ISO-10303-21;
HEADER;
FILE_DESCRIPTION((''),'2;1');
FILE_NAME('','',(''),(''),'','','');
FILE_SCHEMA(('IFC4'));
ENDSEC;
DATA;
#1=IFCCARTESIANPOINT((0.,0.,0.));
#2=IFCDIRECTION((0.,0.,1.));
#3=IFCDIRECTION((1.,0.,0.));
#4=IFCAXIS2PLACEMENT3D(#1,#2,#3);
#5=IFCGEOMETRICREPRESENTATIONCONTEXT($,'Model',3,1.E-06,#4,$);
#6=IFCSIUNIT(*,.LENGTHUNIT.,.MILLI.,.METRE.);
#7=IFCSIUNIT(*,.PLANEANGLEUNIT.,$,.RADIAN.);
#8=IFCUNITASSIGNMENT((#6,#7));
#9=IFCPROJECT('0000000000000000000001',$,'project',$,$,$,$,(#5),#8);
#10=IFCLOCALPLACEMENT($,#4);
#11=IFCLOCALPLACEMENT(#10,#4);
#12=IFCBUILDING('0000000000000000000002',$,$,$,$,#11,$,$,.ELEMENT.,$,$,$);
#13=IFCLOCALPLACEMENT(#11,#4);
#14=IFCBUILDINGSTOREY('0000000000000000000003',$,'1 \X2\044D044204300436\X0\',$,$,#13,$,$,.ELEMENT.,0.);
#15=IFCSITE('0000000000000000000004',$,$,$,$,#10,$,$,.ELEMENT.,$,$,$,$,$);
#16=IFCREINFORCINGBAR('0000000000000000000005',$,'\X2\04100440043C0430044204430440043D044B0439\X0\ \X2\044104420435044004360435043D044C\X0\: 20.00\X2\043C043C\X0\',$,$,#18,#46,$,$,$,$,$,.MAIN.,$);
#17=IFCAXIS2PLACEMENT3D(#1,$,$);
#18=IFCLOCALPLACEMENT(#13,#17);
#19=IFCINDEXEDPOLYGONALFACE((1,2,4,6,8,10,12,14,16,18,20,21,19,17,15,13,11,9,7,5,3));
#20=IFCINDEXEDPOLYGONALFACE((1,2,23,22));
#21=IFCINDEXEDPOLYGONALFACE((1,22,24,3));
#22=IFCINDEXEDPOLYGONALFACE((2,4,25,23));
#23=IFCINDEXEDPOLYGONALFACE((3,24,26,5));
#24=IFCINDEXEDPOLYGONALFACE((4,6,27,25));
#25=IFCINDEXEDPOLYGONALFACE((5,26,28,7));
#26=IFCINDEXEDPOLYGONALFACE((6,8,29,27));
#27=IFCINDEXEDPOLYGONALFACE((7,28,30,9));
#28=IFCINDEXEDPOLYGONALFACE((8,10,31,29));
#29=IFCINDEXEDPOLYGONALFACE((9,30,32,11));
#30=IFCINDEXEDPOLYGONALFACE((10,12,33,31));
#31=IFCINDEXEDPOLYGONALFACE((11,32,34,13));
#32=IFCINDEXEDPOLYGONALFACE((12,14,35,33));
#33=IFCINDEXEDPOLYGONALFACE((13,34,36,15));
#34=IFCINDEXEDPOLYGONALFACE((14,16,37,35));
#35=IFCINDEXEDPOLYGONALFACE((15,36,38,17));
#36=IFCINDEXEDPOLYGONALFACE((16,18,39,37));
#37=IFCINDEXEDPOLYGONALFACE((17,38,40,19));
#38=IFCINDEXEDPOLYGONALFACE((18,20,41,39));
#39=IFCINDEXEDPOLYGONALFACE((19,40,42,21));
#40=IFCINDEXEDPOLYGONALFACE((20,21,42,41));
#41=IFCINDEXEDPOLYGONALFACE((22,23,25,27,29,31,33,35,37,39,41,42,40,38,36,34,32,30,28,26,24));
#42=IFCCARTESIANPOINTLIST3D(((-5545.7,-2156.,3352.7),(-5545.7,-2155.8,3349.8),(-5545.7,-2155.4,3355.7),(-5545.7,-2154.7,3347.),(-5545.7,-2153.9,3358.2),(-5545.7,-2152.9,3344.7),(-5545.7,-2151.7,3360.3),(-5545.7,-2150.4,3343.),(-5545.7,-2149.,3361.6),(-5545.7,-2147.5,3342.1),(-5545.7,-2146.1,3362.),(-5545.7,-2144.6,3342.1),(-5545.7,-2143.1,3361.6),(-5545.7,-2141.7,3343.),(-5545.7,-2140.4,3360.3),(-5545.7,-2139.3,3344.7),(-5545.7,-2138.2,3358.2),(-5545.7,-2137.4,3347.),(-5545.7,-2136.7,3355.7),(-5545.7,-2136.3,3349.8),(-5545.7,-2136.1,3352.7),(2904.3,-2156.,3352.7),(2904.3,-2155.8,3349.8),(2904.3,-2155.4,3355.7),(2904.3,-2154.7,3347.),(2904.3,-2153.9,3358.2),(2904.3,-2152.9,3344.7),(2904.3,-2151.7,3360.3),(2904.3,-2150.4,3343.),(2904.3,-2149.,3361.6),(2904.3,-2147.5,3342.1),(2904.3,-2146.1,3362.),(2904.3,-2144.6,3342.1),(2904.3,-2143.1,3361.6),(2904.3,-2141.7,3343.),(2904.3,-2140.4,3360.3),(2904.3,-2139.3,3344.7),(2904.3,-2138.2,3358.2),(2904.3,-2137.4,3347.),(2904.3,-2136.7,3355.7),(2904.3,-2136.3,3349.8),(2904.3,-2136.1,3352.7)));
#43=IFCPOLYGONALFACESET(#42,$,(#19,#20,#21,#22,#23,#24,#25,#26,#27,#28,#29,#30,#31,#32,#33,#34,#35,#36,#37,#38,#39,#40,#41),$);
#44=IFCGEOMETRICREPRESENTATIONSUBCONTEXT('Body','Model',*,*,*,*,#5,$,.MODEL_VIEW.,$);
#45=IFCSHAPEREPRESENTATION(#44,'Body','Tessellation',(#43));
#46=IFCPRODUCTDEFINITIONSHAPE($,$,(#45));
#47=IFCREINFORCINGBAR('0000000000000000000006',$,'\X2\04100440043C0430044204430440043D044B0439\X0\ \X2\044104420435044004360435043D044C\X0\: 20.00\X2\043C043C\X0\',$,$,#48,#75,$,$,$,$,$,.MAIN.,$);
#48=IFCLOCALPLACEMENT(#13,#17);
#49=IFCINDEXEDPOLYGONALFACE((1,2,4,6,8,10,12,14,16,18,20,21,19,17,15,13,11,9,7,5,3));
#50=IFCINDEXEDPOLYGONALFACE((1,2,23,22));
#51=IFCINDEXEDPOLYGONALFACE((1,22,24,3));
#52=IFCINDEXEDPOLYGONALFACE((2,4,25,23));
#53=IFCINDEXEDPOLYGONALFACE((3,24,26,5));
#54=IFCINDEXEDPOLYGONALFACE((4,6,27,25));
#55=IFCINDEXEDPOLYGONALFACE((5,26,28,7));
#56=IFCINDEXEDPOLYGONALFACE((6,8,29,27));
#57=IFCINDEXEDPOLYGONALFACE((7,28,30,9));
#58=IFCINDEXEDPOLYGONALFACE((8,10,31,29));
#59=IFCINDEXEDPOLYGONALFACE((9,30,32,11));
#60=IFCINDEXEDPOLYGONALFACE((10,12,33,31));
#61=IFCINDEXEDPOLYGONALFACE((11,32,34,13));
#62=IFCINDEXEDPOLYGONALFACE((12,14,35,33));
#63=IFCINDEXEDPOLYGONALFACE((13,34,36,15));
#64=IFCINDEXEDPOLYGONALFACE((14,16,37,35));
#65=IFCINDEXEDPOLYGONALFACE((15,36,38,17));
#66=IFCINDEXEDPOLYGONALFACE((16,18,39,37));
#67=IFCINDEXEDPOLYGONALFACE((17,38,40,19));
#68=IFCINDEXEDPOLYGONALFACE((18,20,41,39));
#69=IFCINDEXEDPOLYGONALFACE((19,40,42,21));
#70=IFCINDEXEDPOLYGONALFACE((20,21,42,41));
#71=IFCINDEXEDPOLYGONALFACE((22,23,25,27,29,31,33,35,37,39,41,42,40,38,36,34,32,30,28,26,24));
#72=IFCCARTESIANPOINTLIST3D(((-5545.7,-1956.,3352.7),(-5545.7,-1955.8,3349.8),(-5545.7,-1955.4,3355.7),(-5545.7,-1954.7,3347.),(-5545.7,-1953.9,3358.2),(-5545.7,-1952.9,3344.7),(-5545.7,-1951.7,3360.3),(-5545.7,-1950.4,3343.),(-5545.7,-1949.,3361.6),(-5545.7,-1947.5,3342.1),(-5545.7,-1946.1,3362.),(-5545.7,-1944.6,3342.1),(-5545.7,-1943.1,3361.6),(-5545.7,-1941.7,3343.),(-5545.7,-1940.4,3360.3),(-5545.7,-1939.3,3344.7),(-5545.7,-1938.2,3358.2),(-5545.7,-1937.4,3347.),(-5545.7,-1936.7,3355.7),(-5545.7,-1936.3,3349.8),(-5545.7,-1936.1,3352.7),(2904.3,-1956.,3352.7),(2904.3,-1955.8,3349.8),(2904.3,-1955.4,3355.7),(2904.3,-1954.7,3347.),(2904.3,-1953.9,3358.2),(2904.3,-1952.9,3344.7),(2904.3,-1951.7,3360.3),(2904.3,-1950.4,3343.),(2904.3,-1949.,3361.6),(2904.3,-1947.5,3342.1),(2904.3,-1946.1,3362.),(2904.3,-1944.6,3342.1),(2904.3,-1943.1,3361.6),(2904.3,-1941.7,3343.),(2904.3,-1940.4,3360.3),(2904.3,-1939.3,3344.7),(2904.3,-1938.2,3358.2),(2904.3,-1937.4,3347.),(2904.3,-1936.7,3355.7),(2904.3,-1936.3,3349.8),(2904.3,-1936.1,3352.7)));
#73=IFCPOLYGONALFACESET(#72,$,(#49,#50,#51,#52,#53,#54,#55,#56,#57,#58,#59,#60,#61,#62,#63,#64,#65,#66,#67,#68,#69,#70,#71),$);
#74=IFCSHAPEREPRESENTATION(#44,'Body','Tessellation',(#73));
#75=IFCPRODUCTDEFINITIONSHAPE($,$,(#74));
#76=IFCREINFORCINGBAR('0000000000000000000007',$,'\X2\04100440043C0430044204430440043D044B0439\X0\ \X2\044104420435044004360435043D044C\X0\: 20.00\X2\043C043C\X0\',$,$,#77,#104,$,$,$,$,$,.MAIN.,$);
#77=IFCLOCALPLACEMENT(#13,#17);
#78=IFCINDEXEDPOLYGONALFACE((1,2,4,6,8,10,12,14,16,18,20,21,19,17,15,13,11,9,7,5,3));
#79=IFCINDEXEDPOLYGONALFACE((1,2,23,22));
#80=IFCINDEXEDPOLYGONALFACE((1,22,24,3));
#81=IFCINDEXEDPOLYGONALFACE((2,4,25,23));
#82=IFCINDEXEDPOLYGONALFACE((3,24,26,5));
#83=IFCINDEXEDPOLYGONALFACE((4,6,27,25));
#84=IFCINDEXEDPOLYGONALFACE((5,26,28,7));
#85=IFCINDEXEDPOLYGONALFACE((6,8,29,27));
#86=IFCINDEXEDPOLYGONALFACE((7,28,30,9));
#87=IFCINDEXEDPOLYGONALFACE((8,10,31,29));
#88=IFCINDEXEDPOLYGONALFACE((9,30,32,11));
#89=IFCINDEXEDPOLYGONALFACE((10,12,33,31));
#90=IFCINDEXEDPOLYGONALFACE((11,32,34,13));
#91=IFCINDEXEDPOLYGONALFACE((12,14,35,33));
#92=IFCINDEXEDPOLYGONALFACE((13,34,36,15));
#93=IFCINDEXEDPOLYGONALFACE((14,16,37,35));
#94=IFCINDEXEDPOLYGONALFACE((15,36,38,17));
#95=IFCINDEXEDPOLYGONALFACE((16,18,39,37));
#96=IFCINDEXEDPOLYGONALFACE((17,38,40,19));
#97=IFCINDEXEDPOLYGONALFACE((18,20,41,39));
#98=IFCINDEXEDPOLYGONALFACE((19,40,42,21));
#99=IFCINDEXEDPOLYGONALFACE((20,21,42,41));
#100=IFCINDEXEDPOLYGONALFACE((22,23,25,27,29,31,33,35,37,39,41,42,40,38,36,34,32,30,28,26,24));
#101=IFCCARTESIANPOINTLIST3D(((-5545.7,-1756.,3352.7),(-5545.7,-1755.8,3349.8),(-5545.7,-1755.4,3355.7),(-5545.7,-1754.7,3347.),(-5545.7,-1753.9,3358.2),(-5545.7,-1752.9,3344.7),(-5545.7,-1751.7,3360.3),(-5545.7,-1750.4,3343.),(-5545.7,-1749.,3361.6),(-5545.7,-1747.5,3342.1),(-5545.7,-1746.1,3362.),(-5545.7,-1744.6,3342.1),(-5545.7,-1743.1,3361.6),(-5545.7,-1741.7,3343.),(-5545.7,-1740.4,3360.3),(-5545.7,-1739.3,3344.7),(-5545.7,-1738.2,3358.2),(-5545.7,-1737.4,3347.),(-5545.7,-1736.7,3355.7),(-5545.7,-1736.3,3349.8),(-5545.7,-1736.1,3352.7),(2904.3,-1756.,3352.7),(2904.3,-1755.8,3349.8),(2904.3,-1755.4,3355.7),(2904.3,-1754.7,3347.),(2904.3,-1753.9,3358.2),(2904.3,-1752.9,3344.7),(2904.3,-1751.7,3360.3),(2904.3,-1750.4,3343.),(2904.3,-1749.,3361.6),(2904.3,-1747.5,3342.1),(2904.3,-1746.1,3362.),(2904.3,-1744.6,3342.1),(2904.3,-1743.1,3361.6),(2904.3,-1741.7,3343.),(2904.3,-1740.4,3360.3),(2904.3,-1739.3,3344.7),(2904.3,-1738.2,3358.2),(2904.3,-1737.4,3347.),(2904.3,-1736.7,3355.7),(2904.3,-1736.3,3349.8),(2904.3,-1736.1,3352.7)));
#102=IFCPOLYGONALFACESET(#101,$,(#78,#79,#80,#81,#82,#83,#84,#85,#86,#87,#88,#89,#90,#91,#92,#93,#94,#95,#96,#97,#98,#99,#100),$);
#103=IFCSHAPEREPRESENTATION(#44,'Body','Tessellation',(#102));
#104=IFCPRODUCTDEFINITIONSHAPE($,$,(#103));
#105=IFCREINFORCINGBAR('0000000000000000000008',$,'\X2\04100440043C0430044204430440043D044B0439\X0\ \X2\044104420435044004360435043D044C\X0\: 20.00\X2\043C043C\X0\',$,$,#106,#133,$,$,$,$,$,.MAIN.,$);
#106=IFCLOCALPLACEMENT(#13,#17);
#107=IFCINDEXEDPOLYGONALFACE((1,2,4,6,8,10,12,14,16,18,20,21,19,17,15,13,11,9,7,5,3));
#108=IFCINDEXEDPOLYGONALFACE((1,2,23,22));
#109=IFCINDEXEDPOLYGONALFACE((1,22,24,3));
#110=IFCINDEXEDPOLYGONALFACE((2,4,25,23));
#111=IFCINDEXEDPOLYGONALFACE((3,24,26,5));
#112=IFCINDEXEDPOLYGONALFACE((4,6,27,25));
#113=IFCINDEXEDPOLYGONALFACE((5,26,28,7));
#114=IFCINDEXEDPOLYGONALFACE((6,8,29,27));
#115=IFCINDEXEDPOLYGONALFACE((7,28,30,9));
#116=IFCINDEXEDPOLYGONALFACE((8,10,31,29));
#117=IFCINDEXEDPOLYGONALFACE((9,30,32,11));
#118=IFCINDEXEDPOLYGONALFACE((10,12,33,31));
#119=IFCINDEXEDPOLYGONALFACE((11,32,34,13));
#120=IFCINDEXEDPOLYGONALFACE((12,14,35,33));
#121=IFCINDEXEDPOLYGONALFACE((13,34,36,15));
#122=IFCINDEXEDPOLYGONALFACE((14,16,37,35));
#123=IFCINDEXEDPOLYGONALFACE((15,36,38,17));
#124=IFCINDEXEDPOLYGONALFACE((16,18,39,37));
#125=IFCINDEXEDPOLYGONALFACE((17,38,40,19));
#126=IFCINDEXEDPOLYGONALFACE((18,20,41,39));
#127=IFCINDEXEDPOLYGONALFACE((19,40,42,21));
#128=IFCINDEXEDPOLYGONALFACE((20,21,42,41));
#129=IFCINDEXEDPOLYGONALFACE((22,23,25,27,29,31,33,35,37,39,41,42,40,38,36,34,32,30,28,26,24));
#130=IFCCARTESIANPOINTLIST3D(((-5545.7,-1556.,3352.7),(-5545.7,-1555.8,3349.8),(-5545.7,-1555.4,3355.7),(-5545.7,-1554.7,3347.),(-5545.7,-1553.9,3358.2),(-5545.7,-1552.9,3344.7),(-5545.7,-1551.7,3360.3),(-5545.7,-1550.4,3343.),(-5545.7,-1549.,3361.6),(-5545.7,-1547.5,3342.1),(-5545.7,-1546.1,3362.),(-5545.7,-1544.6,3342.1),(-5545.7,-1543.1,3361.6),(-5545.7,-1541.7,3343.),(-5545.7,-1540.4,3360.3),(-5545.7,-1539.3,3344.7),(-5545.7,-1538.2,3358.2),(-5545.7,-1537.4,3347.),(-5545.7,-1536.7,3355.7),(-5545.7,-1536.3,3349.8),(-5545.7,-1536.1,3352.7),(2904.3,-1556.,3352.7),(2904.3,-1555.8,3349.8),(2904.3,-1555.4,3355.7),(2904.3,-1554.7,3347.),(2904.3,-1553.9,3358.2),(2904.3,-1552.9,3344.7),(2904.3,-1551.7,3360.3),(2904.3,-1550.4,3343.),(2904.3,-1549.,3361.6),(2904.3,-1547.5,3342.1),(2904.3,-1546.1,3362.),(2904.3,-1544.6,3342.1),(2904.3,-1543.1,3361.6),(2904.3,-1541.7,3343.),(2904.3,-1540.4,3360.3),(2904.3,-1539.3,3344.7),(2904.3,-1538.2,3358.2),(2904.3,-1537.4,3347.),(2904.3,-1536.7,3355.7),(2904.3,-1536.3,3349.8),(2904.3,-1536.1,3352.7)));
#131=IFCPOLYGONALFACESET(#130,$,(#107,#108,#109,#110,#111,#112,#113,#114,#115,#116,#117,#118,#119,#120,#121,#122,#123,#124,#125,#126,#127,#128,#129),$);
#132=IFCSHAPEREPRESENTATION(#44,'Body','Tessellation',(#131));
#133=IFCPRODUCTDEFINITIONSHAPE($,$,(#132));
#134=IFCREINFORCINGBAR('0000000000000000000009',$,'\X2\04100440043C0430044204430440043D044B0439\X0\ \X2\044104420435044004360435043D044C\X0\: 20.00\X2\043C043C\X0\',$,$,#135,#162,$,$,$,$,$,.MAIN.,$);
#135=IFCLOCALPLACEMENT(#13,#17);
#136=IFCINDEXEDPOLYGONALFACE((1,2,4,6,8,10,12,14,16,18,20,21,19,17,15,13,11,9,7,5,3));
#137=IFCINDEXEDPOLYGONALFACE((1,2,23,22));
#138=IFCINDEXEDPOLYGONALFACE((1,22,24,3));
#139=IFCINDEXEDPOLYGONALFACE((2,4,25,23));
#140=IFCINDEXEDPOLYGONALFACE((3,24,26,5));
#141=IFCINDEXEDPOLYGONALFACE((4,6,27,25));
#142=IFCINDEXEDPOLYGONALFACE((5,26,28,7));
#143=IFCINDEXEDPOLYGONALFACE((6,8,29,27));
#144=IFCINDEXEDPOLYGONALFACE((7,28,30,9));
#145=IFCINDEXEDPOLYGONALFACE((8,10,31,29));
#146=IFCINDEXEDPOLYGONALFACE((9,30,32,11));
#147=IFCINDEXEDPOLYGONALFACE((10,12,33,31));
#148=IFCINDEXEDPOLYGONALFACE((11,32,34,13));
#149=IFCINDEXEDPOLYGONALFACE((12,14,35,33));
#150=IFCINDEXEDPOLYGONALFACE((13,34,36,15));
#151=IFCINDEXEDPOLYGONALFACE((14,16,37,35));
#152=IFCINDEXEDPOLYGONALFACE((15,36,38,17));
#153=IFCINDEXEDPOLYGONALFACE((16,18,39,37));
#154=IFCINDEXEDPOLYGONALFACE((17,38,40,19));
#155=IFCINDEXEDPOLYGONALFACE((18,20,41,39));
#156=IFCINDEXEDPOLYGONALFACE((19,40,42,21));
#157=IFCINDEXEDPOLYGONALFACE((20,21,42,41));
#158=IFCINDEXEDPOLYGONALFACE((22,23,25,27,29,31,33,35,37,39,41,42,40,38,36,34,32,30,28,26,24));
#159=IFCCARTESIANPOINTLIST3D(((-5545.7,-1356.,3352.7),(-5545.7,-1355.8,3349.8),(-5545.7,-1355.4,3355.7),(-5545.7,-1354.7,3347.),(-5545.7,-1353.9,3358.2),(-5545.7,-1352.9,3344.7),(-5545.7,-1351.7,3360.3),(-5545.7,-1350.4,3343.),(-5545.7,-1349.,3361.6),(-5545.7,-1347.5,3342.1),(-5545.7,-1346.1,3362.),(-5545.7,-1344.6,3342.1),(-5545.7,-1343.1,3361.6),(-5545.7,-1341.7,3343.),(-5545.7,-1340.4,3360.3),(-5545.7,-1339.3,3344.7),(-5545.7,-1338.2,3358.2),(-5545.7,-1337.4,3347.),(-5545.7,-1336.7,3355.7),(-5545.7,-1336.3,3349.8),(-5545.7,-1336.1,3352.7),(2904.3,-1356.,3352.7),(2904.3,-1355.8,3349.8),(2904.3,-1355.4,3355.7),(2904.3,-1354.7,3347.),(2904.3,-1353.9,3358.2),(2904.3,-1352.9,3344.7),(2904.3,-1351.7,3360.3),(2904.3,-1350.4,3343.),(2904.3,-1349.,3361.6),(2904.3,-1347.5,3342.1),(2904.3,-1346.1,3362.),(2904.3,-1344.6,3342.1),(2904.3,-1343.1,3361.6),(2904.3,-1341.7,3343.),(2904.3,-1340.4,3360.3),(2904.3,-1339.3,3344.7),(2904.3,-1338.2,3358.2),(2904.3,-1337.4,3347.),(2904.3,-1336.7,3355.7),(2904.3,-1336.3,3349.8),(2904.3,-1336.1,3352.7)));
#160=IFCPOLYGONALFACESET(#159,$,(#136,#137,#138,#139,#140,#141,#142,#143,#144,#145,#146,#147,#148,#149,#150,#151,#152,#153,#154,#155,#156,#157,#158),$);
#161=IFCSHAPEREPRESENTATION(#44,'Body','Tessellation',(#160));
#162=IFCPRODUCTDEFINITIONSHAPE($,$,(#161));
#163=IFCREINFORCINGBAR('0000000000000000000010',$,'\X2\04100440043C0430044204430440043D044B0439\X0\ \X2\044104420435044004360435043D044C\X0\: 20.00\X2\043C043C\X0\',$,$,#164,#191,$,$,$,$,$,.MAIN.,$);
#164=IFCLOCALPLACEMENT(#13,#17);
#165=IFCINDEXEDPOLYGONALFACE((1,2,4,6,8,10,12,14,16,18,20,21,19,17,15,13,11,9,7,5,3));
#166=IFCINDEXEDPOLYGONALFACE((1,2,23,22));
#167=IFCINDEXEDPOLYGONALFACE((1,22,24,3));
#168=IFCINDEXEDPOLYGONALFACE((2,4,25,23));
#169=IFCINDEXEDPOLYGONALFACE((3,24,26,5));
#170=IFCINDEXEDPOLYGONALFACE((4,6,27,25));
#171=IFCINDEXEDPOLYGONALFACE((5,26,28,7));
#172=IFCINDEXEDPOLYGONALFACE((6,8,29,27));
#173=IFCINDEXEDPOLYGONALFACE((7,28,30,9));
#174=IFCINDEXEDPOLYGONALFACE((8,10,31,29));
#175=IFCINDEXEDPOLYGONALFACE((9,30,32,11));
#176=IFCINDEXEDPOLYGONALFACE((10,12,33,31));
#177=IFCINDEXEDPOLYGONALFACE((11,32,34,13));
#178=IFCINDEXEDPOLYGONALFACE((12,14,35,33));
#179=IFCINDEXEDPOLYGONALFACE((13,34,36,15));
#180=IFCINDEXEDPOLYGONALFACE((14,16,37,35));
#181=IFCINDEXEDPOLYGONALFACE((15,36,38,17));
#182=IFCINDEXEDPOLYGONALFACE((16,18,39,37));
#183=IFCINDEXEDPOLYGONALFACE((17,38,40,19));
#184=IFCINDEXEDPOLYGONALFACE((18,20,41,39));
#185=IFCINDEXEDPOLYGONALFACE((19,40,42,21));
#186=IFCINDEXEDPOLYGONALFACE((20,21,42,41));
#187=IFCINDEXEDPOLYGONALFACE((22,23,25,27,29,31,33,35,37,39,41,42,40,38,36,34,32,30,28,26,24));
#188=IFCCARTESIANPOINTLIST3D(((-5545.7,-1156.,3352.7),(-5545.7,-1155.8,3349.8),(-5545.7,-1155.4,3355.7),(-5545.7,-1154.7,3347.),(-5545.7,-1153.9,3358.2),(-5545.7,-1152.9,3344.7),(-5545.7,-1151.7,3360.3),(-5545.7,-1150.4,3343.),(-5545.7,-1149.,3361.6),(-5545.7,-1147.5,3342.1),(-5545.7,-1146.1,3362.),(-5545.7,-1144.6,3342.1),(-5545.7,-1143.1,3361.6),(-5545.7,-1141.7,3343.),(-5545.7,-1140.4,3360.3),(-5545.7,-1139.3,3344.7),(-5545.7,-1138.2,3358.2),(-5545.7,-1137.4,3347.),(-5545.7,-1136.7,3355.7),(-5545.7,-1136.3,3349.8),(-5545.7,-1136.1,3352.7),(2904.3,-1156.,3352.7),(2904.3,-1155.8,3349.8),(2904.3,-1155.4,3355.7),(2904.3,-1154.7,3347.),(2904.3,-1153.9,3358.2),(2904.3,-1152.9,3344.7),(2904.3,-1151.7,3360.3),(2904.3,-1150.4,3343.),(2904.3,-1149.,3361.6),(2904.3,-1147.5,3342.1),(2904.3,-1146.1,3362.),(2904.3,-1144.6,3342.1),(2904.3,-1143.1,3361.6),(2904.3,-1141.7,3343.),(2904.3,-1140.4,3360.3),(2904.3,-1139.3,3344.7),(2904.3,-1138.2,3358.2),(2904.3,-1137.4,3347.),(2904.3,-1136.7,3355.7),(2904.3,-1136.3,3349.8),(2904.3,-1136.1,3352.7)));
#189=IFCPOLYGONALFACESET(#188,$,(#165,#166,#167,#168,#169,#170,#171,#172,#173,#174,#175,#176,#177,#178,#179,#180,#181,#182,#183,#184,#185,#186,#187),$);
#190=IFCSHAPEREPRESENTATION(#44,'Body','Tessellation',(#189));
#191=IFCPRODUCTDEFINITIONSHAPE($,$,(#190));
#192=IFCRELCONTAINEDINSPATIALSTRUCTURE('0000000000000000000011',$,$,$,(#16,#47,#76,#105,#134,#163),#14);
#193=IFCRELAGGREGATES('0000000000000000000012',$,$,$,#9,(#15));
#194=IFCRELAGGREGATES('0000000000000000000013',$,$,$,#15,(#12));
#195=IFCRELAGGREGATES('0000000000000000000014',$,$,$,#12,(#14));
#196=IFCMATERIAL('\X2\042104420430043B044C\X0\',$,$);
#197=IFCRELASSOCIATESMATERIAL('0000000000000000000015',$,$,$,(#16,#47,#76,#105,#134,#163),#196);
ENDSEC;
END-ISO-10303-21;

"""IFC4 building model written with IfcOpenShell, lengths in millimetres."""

from ifc_helpers import new_model, entity, si_unit, origin_with_axes, place, context, subcontext, project, spatial, source, transform, mapped, material, element, save


model = new_model("IFC4")

# Units and contexts
model_context = context("Model", 3, precision=1e-06, world=origin_with_axes())
body_context = subcontext(model_context, "Body", "Model", "MODEL_VIEW")
ifc_project = project(units=[si_unit("LENGTHUNIT", "METRE", prefix="MILLI"), si_unit("PLANEANGLEUNIT", "RADIAN")], contexts=[model_context])

# Site, building, storey
site_placement = place(None, origin_with_axes())
site = spatial("IfcSite", under=ifc_project, at=site_placement, CompositionType="ELEMENT")
building_placement = place(site_placement, origin_with_axes())
building = spatial("IfcBuilding", under=site, at=building_placement, CompositionType="ELEMENT")
storey_placement = place(building_placement, origin_with_axes())
storey = spatial("IfcBuildingStorey", under=building, at=storey_placement, Name="1 этаж", CompositionType="ELEMENT", Elevation=0.0)

# Shared definitions
ifc_material_1 = material(Name="Сталь")

# Reinforcing bars
shared_shape_1 = source(origin_with_axes(), body_context, "Body", "AdvancedSweptSolid", [
    entity("IfcSweptDiskSolid", entity("IfcIndexedPolyCurve", entity("IfcCartesianPointList3D", [[0.0, 0.0, 0.0], [8450.0, 0.0, 0.0]]), [entity("IfcLineIndex", [1, 2])]), 10.0),
])
reinforcing_bar_1_placement = place(storey_placement, origin_with_axes())
element("IfcReinforcingBar", 1, at=reinforcing_bar_1_placement, inside=storey, material=ifc_material_1, Name="Арматурный стержень: 20.00мм", PredefinedType="MAIN", context=body_context, shape_type="MappedRepresentation", body=[
    mapped(shared_shape_1, transform((-5545.7, -2146.1, 3352.0), x_axis=(1.0, 0.0, 0.0), y_axis=(0.0, 1.0, 0.0), z_axis=(0.0, 0.0, 1.0), scale=1.0)),
])
reinforcing_bar_2_placement = place(storey_placement, origin_with_axes())
element("IfcReinforcingBar", 2, at=reinforcing_bar_2_placement, inside=storey, material=ifc_material_1, Name="Арматурный стержень: 20.00мм", PredefinedType="MAIN", context=body_context, shape_type="MappedRepresentation", body=[
    mapped(shared_shape_1, transform((-5545.7, -1946.1, 3352.0), x_axis=(1.0, 0.0, 0.0), y_axis=(0.0, 1.0, 0.0), z_axis=(0.0, 0.0, 1.0), scale=1.0)),
])
reinforcing_bar_3_placement = place(storey_placement, origin_with_axes())
element("IfcReinforcingBar", 3, at=reinforcing_bar_3_placement, inside=storey, material=ifc_material_1, Name="Арматурный стержень: 20.00мм", PredefinedType="MAIN", context=body_context, shape_type="MappedRepresentation", body=[
    mapped(shared_shape_1, transform((-5545.7, -1746.1, 3352.0), x_axis=(1.0, 0.0, 0.0), y_axis=(0.0, 1.0, 0.0), z_axis=(0.0, 0.0, 1.0), scale=1.0)),
])
reinforcing_bar_4_placement = place(storey_placement, origin_with_axes())
element("IfcReinforcingBar", 4, at=reinforcing_bar_4_placement, inside=storey, material=ifc_material_1, Name="Арматурный стержень: 20.00мм", PredefinedType="MAIN", context=body_context, shape_type="MappedRepresentation", body=[
    mapped(shared_shape_1, transform((-5545.7, -1546.1, 3352.0), x_axis=(1.0, 0.0, 0.0), y_axis=(0.0, 1.0, 0.0), z_axis=(0.0, 0.0, 1.0), scale=1.0)),
])
reinforcing_bar_5_placement = place(storey_placement, origin_with_axes())
element("IfcReinforcingBar", 5, at=reinforcing_bar_5_placement, inside=storey, material=ifc_material_1, Name="Арматурный стержень: 20.00мм", PredefinedType="MAIN", context=body_context, shape_type="MappedRepresentation", body=[
    mapped(shared_shape_1, transform((-5545.7, -1346.1, 3352.0), x_axis=(1.0, 0.0, 0.0), y_axis=(0.0, 1.0, 0.0), z_axis=(0.0, 0.0, 1.0), scale=1.0)),
])
reinforcing_bar_6_placement = place(storey_placement, origin_with_axes())
element("IfcReinforcingBar", 6, at=reinforcing_bar_6_placement, inside=storey, material=ifc_material_1, Name="Арматурный стержень: 20.00мм", PredefinedType="MAIN", context=body_context, shape_type="MappedRepresentation", body=[
    mapped(shared_shape_1, transform((-5545.7, -1146.1, 3352.0), x_axis=(1.0, 0.0, 0.0), y_axis=(0.0, 1.0, 0.0), z_axis=(0.0, 0.0, 1.0), scale=1.0)),
])

save(model, "model.ifc")
